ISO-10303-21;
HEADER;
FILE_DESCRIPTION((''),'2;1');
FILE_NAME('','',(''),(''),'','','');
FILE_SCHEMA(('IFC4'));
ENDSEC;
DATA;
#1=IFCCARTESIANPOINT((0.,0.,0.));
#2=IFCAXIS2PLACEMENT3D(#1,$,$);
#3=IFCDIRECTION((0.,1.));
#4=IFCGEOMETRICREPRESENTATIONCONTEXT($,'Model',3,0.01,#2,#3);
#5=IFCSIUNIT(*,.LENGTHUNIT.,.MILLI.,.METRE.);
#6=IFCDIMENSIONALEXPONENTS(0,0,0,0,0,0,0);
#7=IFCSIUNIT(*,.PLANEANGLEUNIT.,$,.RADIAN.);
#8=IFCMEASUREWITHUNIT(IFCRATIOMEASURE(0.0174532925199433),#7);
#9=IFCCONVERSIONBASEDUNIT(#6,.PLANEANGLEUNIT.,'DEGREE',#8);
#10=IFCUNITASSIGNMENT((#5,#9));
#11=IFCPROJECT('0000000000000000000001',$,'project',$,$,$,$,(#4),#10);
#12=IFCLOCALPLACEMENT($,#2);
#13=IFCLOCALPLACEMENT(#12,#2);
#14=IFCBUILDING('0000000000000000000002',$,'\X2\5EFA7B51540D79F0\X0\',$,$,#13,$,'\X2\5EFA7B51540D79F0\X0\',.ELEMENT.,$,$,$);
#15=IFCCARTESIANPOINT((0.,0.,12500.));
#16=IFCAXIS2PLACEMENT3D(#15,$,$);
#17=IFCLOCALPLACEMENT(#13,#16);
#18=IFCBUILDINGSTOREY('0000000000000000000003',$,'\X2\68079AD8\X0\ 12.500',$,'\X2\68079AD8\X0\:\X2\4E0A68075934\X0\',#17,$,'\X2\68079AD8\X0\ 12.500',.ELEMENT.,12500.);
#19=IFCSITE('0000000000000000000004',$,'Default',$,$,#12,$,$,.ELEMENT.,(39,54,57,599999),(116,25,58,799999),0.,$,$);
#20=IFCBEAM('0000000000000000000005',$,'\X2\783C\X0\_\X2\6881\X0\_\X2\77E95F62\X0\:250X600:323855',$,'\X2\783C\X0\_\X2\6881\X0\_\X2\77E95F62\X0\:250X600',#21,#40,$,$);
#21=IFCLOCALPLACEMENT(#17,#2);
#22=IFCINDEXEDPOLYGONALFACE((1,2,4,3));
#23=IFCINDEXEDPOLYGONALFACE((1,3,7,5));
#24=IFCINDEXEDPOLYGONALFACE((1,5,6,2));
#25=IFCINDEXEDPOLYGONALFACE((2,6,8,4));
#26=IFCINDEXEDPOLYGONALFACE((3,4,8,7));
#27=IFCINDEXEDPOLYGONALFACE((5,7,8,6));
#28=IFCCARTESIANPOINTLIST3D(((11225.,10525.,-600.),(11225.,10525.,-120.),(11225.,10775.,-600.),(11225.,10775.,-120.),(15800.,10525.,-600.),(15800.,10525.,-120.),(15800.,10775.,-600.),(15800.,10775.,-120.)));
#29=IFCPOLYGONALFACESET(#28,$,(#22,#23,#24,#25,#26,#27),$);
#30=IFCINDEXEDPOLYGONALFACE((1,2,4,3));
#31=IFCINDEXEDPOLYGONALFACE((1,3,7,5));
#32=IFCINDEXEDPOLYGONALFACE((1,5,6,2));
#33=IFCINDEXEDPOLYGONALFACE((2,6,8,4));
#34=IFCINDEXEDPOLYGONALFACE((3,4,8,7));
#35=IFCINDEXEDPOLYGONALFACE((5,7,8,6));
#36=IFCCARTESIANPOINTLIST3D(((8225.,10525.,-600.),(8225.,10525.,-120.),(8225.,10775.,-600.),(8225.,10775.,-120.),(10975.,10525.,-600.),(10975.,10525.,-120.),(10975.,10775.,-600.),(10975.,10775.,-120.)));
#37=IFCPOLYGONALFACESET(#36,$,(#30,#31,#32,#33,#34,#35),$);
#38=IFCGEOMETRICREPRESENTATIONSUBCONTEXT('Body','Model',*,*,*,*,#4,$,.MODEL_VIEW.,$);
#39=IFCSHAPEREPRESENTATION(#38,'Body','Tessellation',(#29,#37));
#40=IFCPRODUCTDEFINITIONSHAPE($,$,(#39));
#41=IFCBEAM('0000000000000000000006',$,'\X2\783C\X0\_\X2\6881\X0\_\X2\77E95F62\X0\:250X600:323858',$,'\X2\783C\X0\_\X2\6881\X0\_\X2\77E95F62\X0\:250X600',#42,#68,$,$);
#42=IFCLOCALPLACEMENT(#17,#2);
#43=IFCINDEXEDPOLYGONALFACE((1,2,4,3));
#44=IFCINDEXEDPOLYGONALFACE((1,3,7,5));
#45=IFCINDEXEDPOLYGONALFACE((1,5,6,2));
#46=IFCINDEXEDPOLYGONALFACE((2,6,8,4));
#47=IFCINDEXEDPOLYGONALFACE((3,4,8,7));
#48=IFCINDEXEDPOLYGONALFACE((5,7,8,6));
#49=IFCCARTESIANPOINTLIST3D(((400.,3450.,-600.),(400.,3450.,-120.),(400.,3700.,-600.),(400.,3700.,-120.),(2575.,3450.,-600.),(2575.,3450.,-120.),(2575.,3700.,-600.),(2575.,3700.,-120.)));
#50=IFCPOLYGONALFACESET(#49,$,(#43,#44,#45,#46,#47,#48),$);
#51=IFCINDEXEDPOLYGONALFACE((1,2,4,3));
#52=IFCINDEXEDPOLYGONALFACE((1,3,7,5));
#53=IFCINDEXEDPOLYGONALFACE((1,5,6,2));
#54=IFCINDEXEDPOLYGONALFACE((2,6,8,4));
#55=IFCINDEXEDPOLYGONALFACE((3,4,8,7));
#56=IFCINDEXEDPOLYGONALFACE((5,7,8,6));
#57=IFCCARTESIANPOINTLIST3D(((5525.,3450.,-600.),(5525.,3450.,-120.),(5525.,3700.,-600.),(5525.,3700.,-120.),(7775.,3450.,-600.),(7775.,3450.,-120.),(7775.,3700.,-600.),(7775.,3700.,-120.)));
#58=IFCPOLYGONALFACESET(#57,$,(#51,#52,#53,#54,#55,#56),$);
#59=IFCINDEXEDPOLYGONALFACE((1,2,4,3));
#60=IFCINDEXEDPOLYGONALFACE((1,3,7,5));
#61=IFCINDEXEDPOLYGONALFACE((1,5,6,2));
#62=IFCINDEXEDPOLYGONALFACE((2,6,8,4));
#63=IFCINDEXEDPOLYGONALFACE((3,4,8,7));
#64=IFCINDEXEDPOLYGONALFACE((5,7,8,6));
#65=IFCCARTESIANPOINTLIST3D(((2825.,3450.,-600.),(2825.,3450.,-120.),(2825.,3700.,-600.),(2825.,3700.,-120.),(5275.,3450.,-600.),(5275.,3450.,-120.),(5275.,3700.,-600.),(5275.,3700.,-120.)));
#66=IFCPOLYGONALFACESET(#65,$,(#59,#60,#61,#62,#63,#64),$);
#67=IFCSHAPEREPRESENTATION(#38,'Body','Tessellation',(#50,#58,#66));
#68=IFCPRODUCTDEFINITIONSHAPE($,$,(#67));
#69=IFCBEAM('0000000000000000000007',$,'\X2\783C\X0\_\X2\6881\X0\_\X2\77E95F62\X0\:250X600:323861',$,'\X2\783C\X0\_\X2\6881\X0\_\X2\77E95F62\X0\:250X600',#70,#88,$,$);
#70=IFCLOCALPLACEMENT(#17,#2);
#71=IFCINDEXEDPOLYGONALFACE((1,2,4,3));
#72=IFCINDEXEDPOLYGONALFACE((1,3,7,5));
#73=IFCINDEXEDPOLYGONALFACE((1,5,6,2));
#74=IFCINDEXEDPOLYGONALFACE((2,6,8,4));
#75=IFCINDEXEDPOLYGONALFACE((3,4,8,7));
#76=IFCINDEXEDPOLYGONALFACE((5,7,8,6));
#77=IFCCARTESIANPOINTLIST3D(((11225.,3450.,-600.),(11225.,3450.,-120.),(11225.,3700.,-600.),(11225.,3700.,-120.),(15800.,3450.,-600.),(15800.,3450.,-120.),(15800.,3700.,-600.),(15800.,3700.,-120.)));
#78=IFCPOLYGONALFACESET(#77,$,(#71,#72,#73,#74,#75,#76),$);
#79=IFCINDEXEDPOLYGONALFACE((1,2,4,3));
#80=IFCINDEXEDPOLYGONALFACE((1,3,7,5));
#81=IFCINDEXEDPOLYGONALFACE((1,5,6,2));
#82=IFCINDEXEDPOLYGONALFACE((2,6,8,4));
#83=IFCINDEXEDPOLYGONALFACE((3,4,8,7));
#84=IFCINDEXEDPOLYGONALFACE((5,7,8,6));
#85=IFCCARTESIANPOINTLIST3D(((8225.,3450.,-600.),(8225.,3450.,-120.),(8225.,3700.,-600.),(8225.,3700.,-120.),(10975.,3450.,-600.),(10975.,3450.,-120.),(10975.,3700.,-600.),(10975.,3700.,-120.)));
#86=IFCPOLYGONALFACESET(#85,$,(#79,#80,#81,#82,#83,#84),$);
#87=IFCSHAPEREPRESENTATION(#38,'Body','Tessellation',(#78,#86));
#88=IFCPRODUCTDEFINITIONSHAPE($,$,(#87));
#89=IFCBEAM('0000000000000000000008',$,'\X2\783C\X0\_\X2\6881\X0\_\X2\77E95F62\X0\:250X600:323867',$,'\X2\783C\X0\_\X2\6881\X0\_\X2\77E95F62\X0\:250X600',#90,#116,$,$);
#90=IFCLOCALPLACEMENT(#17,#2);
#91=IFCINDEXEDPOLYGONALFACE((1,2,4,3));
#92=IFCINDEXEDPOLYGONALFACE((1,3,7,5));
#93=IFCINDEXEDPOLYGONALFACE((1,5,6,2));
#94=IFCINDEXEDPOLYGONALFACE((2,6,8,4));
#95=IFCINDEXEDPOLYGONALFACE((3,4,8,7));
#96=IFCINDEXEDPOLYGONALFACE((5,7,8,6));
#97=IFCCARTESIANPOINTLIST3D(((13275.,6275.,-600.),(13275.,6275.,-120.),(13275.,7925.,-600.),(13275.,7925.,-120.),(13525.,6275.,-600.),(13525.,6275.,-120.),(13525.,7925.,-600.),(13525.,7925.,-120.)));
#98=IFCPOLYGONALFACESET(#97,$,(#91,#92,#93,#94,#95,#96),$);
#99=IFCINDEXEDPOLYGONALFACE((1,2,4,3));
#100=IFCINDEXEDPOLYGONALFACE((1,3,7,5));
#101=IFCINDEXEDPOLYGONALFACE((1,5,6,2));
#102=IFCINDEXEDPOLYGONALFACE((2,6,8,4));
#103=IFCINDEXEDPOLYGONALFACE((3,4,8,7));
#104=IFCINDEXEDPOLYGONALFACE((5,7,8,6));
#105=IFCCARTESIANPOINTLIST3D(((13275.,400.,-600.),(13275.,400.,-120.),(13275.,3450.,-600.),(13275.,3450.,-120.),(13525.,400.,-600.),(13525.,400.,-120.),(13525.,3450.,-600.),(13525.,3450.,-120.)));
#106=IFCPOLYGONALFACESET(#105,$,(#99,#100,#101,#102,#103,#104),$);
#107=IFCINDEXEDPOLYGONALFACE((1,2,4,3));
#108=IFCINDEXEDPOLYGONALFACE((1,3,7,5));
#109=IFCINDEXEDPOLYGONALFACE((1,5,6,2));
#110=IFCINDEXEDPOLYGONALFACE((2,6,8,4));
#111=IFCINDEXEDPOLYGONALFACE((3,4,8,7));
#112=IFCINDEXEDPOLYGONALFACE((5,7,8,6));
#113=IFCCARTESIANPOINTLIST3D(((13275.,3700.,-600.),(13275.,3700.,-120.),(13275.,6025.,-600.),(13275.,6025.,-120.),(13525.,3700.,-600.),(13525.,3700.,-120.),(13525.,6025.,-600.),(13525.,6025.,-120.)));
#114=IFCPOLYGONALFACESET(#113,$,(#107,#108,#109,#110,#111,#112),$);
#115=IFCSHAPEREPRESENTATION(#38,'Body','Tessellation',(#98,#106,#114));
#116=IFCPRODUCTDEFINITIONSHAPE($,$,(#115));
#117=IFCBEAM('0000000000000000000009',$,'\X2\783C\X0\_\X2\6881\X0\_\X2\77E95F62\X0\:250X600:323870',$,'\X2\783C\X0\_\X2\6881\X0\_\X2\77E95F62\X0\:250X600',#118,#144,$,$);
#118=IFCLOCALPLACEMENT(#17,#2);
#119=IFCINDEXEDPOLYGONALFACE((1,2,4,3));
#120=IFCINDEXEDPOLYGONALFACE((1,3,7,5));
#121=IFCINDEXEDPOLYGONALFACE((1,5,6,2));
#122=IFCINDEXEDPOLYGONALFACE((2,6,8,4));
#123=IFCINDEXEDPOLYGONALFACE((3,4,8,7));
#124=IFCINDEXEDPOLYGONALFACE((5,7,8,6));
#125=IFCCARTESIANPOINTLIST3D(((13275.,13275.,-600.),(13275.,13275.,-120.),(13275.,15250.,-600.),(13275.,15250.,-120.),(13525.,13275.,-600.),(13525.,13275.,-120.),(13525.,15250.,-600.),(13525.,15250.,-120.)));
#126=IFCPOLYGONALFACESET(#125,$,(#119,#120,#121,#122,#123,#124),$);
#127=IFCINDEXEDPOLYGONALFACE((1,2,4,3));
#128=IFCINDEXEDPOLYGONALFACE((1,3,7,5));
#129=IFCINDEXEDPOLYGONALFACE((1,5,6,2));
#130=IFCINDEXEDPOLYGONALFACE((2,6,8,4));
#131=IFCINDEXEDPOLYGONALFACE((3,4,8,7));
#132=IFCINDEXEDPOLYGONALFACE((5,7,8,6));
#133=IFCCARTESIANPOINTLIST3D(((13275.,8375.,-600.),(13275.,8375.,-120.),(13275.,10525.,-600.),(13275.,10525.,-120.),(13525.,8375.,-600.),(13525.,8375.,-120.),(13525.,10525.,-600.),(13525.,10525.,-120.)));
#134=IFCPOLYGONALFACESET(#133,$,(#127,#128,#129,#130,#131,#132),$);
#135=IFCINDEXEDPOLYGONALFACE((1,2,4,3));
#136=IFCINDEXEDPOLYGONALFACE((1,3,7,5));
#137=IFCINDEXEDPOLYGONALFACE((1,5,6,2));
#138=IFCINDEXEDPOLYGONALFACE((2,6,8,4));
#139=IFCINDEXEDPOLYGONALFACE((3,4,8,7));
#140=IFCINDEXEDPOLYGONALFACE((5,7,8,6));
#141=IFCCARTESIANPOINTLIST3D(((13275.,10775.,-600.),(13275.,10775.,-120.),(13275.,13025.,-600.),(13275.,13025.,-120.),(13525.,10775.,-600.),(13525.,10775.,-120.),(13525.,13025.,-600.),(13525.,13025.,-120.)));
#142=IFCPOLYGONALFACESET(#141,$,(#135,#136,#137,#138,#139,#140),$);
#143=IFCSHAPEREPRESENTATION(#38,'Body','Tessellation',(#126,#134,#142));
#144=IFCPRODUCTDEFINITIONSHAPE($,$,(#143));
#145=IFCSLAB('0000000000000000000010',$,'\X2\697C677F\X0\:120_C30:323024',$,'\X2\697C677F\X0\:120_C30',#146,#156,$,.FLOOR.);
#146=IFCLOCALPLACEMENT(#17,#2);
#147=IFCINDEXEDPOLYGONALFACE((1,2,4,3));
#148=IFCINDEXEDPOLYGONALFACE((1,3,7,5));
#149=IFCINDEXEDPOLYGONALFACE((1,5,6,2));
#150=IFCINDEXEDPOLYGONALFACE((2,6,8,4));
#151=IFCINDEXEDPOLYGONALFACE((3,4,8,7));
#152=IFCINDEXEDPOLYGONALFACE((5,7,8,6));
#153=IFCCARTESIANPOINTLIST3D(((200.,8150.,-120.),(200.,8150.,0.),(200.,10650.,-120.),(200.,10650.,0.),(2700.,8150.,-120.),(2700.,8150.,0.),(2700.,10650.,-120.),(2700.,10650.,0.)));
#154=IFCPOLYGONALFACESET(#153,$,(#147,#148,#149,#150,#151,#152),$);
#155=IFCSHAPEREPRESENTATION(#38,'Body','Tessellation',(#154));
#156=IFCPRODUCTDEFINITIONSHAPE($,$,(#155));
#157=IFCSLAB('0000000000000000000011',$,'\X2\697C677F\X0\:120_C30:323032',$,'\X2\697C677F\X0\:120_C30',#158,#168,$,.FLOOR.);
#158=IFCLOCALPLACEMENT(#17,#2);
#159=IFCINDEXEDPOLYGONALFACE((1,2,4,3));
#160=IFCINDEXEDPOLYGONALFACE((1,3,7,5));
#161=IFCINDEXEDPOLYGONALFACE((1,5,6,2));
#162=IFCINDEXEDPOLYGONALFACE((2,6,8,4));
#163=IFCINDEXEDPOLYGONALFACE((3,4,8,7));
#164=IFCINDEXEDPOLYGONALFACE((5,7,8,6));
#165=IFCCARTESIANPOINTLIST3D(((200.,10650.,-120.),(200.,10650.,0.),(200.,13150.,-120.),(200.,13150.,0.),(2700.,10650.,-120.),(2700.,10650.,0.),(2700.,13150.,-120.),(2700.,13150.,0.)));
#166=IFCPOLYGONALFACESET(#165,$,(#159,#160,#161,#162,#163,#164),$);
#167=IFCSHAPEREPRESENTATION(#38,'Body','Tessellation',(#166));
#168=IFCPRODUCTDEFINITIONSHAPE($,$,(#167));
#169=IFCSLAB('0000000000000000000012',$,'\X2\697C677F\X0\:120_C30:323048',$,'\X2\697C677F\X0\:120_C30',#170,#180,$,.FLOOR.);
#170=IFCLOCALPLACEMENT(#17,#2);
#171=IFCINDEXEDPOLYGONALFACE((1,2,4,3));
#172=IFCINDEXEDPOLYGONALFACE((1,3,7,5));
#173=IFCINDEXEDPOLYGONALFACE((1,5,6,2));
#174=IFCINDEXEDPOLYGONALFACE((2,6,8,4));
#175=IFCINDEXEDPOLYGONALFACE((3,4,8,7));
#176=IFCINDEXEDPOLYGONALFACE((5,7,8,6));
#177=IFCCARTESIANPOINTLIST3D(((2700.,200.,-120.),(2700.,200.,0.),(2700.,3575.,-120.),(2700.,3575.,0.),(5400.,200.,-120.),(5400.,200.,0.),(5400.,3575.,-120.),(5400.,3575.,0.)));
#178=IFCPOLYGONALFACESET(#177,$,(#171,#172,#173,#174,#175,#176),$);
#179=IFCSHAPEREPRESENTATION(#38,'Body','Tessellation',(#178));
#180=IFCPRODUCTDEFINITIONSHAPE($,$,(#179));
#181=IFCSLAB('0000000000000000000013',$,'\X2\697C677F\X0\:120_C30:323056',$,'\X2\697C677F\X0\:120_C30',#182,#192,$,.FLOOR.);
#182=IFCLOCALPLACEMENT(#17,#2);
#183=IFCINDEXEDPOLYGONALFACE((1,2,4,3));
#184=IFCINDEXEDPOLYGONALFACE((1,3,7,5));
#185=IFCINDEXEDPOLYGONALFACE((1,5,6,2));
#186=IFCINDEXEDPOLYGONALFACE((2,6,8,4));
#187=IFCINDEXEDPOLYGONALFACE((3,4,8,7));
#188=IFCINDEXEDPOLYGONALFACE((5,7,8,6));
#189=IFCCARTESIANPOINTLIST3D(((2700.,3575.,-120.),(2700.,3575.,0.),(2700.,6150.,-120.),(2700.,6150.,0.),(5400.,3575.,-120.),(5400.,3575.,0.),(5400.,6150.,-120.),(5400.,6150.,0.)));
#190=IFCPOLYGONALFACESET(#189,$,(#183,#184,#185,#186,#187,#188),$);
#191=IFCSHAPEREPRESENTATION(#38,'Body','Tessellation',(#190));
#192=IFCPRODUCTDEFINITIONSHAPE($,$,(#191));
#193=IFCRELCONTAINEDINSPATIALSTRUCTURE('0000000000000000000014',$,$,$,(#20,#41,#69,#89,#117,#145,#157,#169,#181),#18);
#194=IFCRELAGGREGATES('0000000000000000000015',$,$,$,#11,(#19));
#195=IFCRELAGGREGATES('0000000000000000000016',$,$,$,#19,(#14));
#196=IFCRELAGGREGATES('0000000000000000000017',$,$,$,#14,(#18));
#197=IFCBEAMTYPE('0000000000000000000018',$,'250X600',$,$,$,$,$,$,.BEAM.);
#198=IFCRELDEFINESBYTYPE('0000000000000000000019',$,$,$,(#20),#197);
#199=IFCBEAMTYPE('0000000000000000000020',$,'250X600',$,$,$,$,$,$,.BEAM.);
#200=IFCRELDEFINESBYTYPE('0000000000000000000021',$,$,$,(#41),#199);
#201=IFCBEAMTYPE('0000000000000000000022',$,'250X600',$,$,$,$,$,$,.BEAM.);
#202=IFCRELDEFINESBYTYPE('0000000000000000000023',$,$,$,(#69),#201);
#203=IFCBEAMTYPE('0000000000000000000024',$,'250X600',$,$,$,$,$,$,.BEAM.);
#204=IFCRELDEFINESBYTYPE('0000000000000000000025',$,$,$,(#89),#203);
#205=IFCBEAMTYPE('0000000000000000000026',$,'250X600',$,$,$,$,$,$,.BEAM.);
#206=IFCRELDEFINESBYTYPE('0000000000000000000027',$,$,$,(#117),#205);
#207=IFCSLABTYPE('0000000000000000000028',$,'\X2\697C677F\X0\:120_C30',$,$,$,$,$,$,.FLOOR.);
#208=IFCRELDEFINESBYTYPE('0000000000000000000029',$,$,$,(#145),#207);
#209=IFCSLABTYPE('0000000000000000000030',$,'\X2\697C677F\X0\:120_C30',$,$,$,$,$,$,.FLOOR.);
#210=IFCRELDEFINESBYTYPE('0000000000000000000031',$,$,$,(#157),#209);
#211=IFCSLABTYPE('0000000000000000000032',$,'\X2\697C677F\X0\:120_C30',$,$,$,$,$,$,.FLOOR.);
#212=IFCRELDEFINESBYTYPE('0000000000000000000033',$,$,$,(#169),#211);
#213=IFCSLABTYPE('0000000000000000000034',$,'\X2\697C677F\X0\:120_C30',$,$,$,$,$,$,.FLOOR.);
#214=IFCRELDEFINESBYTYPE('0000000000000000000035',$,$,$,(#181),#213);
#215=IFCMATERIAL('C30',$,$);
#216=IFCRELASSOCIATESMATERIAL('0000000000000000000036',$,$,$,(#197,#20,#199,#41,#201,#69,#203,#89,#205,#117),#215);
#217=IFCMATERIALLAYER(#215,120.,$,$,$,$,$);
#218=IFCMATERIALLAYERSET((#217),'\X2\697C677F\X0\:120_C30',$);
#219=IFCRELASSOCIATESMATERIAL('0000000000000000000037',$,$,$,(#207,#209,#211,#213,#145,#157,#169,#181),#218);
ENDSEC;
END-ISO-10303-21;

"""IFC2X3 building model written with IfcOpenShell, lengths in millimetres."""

from ifc_helpers import new_model, entity, si_unit, converted_unit, direction, frame, frame_2d, origin, origin_2d_with_axis, place, context, subcontext, project, spatial, rectangle, extrude, source, transform, mapped, material, layer, layer_set, layer_usage, type_object, type_shapes, element, save


model = new_model("IFC2X3")

# Units and contexts
model_context = context("Model", 3, precision=0.01, world=origin(), true_north=direction((0.0, 1.0)))
body_context = subcontext(model_context, "Body", "Model", "MODEL_VIEW")
ifc_project = project(units=[si_unit("LENGTHUNIT", "METRE", prefix="MILLI"), converted_unit("PLANEANGLEUNIT", "DEGREE", entity("IfcRatioMeasure", 0.0174532925199433), si_unit("PLANEANGLEUNIT", "RADIAN"), dimensions=[0, 0, 0, 0, 0, 0, 0])], contexts=[model_context])

# Site, building, storey
site_placement = place(None, origin())
site = spatial("IfcSite", under=ifc_project, at=site_placement, Name="Default", CompositionType="ELEMENT", RefLatitude=(39, 54, 57, 599999), RefLongitude=(116, 25, 58, 799999), RefElevation=0.0)
building_placement = place(site_placement, origin())
building = spatial("IfcBuilding", under=site, at=building_placement, Name="建筑名称", LongName="建筑名称", CompositionType="ELEMENT")
storey_placement = place(building_placement, frame((0.0, 0.0, 12500.0)))
storey = spatial("IfcBuildingStorey", under=building, at=storey_placement, Name="标高 12.500", ObjectType="标高:上标头", LongName="标高 12.500", CompositionType="ELEMENT", Elevation=12500.0)

# Shared definitions
ifc_material = material(Name="C30")

# Beams
beam_type_1 = type_object("IfcBeamType", Name="250X600", PredefinedType="BEAM", material=ifc_material)
shared_shape_1 = source(origin(), body_context, "Body", "SweptSolid", [
    extrude(rectangle(XDim=480.0, YDim=250.0, at=frame_2d((0.0, 0.0), x_axis=(1.0, 0.0))), frame((11225.0, 10650.0, 12140.0), z_axis=(1.0, 0.0, 0.0), x_axis=(0.0, 0.0, -1.0)), (0.0, 0.0, 1.0), 4575.0),
    extrude(rectangle(XDim=480.0, YDim=250.0, at=frame_2d((0.0, 0.0), x_axis=(1.0, 0.0))), frame((8225.0, 10650.0, 12140.0), z_axis=(1.0, 0.0, 0.0), x_axis=(0.0, 0.0, -1.0)), (0.0, 0.0, 1.0), 2750.0),
])
type_shapes(beam_type_1, [shared_shape_1])
beam_1_placement = place(storey_placement, frame((0.0, 0.0, -12500.0)))
element("IfcBeam", 1, at=beam_1_placement, inside=storey, type_object=beam_type_1, material=ifc_material, Name="砼_梁_矩形:250X600:323855", ObjectType="砼_梁_矩形:250X600", context=body_context, shape_type="MappedRepresentation", body=[
    mapped(shared_shape_1, transform((0.0, 0.0, 0.0), scale=1.0)),
])
beam_type_2 = type_object("IfcBeamType", Name="250X600", PredefinedType="BEAM", material=ifc_material)
shared_shape_2 = source(origin(), body_context, "Body", "SweptSolid", [
    extrude(rectangle(XDim=480.0, YDim=250.0, at=frame_2d((0.0, 0.0), x_axis=(1.0, 0.0))), frame((400.0, 3575.0, 12140.0), z_axis=(1.0, 0.0, 0.0), x_axis=(0.0, 0.0, -1.0)), (0.0, 0.0, 1.0), 2175.0),
    extrude(rectangle(XDim=480.0, YDim=250.0, at=frame_2d((0.0, 0.0), x_axis=(1.0, 0.0))), frame((5525.0, 3575.0, 12140.0), z_axis=(1.0, 0.0, 0.0), x_axis=(0.0, 0.0, -1.0)), (0.0, 0.0, 1.0), 2250.0),
    extrude(rectangle(XDim=480.0, YDim=250.0, at=frame_2d((0.0, 0.0), x_axis=(1.0, 0.0))), frame((2825.0, 3575.0, 12140.0), z_axis=(1.0, 0.0, 0.0), x_axis=(0.0, 0.0, -1.0)), (0.0, 0.0, 1.0), 2450.0),
])
type_shapes(beam_type_2, [shared_shape_2])
beam_2_placement = place(storey_placement, frame((0.0, 0.0, -12500.0)))
element("IfcBeam", 2, at=beam_2_placement, inside=storey, type_object=beam_type_2, material=ifc_material, Name="砼_梁_矩形:250X600:323858", ObjectType="砼_梁_矩形:250X600", context=body_context, shape_type="MappedRepresentation", body=[
    mapped(shared_shape_2, transform((0.0, 0.0, 0.0), scale=1.0)),
])
beam_type_3 = type_object("IfcBeamType", Name="250X600", PredefinedType="BEAM", material=ifc_material)
shared_shape_3 = source(origin(), body_context, "Body", "SweptSolid", [
    extrude(rectangle(XDim=480.0, YDim=250.0, at=frame_2d((0.0, 0.0), x_axis=(1.0, 0.0))), frame((11225.0, 3575.0, 12140.0), z_axis=(1.0, 0.0, 0.0), x_axis=(0.0, 0.0, -1.0)), (0.0, 0.0, 1.0), 4575.0),
    extrude(rectangle(XDim=480.0, YDim=250.0, at=frame_2d((0.0, 0.0), x_axis=(1.0, 0.0))), frame((8225.0, 3575.0, 12140.0), z_axis=(1.0, 0.0, 0.0), x_axis=(0.0, 0.0, -1.0)), (0.0, 0.0, 1.0), 2750.0),
])
type_shapes(beam_type_3, [shared_shape_3])
beam_3_placement = place(storey_placement, frame((0.0, 0.0, -12500.0)))
element("IfcBeam", 3, at=beam_3_placement, inside=storey, type_object=beam_type_3, material=ifc_material, Name="砼_梁_矩形:250X600:323861", ObjectType="砼_梁_矩形:250X600", context=body_context, shape_type="MappedRepresentation", body=[
    mapped(shared_shape_3, transform((0.0, 0.0, 0.0), scale=1.0)),
])
beam_type_4 = type_object("IfcBeamType", Name="250X600", PredefinedType="BEAM", material=ifc_material)
shared_shape_4 = source(origin(), body_context, "Body", "SweptSolid", [
    extrude(rectangle(XDim=480.0, YDim=250.0, at=frame_2d((0.0, 0.0), x_axis=(0.0, 1.0))), frame((13400.0, 6275.0, 12140.0), z_axis=(0.0, 1.0, 0.0), x_axis=(-1.0, 0.0, 0.0)), (0.0, 0.0, 1.0), 1650.0),
    extrude(rectangle(XDim=480.0, YDim=250.0, at=frame_2d((0.0, 0.0), x_axis=(0.0, 1.0))), frame((13400.0, 400.0, 12140.0), z_axis=(0.0, 1.0, 0.0), x_axis=(-1.0, 0.0, 0.0)), (0.0, 0.0, 1.0), 3050.0),
    extrude(rectangle(XDim=480.0, YDim=250.0, at=frame_2d((0.0, 0.0), x_axis=(0.0, 1.0))), frame((13400.0, 3700.0, 12140.0), z_axis=(0.0, 1.0, 0.0), x_axis=(-1.0, 0.0, 0.0)), (0.0, 0.0, 1.0), 2325.0),
])
type_shapes(beam_type_4, [shared_shape_4])
beam_4_placement = place(storey_placement, frame((0.0, 0.0, -12500.0)))
element("IfcBeam", 4, at=beam_4_placement, inside=storey, type_object=beam_type_4, material=ifc_material, Name="砼_梁_矩形:250X600:323867", ObjectType="砼_梁_矩形:250X600", context=body_context, shape_type="MappedRepresentation", body=[
    mapped(shared_shape_4, transform((0.0, 0.0, 0.0), scale=1.0)),
])
beam_type_5 = type_object("IfcBeamType", Name="250X600", PredefinedType="BEAM", material=ifc_material)
shared_shape_5 = source(origin(), body_context, "Body", "SweptSolid", [
    extrude(rectangle(XDim=480.0, YDim=250.0, at=frame_2d((0.0, 0.0), x_axis=(0.0, 1.0))), frame((13400.0, 13275.0, 12140.0), z_axis=(0.0, 1.0, 0.0), x_axis=(-1.0, 0.0, 0.0)), (0.0, 0.0, 1.0), 1975.0),
    extrude(rectangle(XDim=480.0, YDim=250.0, at=frame_2d((0.0, 0.0), x_axis=(0.0, 1.0))), frame((13400.0, 8375.0, 12140.0), z_axis=(0.0, 1.0, 0.0), x_axis=(-1.0, 0.0, 0.0)), (0.0, 0.0, 1.0), 2150.0),
    extrude(rectangle(XDim=480.0, YDim=250.0, at=frame_2d((0.0, 0.0), x_axis=(0.0, 1.0))), frame((13400.0, 10775.0, 12140.0), z_axis=(0.0, 1.0, 0.0), x_axis=(-1.0, 0.0, 0.0)), (0.0, 0.0, 1.0), 2250.0),
])
type_shapes(beam_type_5, [shared_shape_5])
beam_5_placement = place(storey_placement, frame((0.0, 0.0, -12500.0)))
element("IfcBeam", 5, at=beam_5_placement, inside=storey, type_object=beam_type_5, material=ifc_material, Name="砼_梁_矩形:250X600:323870", ObjectType="砼_梁_矩形:250X600", context=body_context, shape_type="MappedRepresentation", body=[
    mapped(shared_shape_5, transform((0.0, 0.0, 0.0), scale=1.0)),
])

# Slabs
ifc_layer = layer(ifc_material, 120.0)
ifc_layer_set = layer_set([ifc_layer], Name="楼板:120_C30")
ifc_layer_usage_1 = layer_usage(ifc_layer_set, "AXIS3", "POSITIVE", 0.0)
slab_type_1 = type_object("IfcSlabType", Name="楼板:120_C30", PredefinedType="FLOOR", material=ifc_layer_set)
slab_1_placement = place(storey_placement, origin())
element("IfcSlab", 6, at=slab_1_placement, inside=storey, type_object=slab_type_1, material=ifc_layer_usage_1, Name="楼板:120_C30:323024", ObjectType="楼板:120_C30", PredefinedType="FLOOR", context=body_context, shape_type="SweptSolid", body=[
    extrude(rectangle(XDim=2500.0, YDim=2500.0, at=frame_2d((0.0, 0.0), x_axis=(1.0, 0.0))), frame((1450.0, 9400.0, 0.0), z_axis=(0.0, 0.0, -1.0), x_axis=(0.0, 1.0, 0.0)), (0.0, 0.0, 1.0), 120.0),
])
ifc_layer_usage_2 = layer_usage(ifc_layer_set, "AXIS3", "POSITIVE", 0.0)
slab_type_2 = type_object("IfcSlabType", Name="楼板:120_C30", PredefinedType="FLOOR", material=ifc_layer_set)
slab_2_placement = place(storey_placement, origin())
element("IfcSlab", 7, at=slab_2_placement, inside=storey, type_object=slab_type_2, material=ifc_layer_usage_2, Name="楼板:120_C30:323032", ObjectType="楼板:120_C30", PredefinedType="FLOOR", context=body_context, shape_type="SweptSolid", body=[
    extrude(rectangle(XDim=2500.0, YDim=2500.0, at=origin_2d_with_axis()), frame((1450.0, 11900.0, 0.0), z_axis=(0.0, 0.0, -1.0), x_axis=(0.0, 1.0, 0.0)), (0.0, 0.0, 1.0), 120.0),
])
ifc_layer_usage_3 = layer_usage(ifc_layer_set, "AXIS3", "POSITIVE", 0.0)
slab_type_3 = type_object("IfcSlabType", Name="楼板:120_C30", PredefinedType="FLOOR", material=ifc_layer_set)
slab_3_placement = place(storey_placement, origin())
element("IfcSlab", 8, at=slab_3_placement, inside=storey, type_object=slab_type_3, material=ifc_layer_usage_3, Name="楼板:120_C30:323048", ObjectType="楼板:120_C30", PredefinedType="FLOOR", context=body_context, shape_type="SweptSolid", body=[
    extrude(rectangle(XDim=3375.0, YDim=2700.0, at=origin_2d_with_axis()), frame((4050.0, 1887.5, 0.0), z_axis=(0.0, 0.0, -1.0), x_axis=(0.0, 1.0, 0.0)), (0.0, 0.0, 1.0), 120.0),
])
ifc_layer_usage_4 = layer_usage(ifc_layer_set, "AXIS3", "POSITIVE", 0.0)
slab_type_4 = type_object("IfcSlabType", Name="楼板:120_C30", PredefinedType="FLOOR", material=ifc_layer_set)
slab_4_placement = place(storey_placement, origin())
element("IfcSlab", 9, at=slab_4_placement, inside=storey, type_object=slab_type_4, material=ifc_layer_usage_4, Name="楼板:120_C30:323056", ObjectType="楼板:120_C30", PredefinedType="FLOOR", context=body_context, shape_type="SweptSolid", body=[
    extrude(rectangle(XDim=2575.0, YDim=2700.0, at=frame_2d((0.0, 0.0), x_axis=(1.0, 0.0))), frame((4050.0, 4862.5, 0.0), z_axis=(0.0, 0.0, -1.0), x_axis=(0.0, 1.0, 0.0)), (0.0, 0.0, 1.0), 120.0),
])

save(model, "model.ifc")
